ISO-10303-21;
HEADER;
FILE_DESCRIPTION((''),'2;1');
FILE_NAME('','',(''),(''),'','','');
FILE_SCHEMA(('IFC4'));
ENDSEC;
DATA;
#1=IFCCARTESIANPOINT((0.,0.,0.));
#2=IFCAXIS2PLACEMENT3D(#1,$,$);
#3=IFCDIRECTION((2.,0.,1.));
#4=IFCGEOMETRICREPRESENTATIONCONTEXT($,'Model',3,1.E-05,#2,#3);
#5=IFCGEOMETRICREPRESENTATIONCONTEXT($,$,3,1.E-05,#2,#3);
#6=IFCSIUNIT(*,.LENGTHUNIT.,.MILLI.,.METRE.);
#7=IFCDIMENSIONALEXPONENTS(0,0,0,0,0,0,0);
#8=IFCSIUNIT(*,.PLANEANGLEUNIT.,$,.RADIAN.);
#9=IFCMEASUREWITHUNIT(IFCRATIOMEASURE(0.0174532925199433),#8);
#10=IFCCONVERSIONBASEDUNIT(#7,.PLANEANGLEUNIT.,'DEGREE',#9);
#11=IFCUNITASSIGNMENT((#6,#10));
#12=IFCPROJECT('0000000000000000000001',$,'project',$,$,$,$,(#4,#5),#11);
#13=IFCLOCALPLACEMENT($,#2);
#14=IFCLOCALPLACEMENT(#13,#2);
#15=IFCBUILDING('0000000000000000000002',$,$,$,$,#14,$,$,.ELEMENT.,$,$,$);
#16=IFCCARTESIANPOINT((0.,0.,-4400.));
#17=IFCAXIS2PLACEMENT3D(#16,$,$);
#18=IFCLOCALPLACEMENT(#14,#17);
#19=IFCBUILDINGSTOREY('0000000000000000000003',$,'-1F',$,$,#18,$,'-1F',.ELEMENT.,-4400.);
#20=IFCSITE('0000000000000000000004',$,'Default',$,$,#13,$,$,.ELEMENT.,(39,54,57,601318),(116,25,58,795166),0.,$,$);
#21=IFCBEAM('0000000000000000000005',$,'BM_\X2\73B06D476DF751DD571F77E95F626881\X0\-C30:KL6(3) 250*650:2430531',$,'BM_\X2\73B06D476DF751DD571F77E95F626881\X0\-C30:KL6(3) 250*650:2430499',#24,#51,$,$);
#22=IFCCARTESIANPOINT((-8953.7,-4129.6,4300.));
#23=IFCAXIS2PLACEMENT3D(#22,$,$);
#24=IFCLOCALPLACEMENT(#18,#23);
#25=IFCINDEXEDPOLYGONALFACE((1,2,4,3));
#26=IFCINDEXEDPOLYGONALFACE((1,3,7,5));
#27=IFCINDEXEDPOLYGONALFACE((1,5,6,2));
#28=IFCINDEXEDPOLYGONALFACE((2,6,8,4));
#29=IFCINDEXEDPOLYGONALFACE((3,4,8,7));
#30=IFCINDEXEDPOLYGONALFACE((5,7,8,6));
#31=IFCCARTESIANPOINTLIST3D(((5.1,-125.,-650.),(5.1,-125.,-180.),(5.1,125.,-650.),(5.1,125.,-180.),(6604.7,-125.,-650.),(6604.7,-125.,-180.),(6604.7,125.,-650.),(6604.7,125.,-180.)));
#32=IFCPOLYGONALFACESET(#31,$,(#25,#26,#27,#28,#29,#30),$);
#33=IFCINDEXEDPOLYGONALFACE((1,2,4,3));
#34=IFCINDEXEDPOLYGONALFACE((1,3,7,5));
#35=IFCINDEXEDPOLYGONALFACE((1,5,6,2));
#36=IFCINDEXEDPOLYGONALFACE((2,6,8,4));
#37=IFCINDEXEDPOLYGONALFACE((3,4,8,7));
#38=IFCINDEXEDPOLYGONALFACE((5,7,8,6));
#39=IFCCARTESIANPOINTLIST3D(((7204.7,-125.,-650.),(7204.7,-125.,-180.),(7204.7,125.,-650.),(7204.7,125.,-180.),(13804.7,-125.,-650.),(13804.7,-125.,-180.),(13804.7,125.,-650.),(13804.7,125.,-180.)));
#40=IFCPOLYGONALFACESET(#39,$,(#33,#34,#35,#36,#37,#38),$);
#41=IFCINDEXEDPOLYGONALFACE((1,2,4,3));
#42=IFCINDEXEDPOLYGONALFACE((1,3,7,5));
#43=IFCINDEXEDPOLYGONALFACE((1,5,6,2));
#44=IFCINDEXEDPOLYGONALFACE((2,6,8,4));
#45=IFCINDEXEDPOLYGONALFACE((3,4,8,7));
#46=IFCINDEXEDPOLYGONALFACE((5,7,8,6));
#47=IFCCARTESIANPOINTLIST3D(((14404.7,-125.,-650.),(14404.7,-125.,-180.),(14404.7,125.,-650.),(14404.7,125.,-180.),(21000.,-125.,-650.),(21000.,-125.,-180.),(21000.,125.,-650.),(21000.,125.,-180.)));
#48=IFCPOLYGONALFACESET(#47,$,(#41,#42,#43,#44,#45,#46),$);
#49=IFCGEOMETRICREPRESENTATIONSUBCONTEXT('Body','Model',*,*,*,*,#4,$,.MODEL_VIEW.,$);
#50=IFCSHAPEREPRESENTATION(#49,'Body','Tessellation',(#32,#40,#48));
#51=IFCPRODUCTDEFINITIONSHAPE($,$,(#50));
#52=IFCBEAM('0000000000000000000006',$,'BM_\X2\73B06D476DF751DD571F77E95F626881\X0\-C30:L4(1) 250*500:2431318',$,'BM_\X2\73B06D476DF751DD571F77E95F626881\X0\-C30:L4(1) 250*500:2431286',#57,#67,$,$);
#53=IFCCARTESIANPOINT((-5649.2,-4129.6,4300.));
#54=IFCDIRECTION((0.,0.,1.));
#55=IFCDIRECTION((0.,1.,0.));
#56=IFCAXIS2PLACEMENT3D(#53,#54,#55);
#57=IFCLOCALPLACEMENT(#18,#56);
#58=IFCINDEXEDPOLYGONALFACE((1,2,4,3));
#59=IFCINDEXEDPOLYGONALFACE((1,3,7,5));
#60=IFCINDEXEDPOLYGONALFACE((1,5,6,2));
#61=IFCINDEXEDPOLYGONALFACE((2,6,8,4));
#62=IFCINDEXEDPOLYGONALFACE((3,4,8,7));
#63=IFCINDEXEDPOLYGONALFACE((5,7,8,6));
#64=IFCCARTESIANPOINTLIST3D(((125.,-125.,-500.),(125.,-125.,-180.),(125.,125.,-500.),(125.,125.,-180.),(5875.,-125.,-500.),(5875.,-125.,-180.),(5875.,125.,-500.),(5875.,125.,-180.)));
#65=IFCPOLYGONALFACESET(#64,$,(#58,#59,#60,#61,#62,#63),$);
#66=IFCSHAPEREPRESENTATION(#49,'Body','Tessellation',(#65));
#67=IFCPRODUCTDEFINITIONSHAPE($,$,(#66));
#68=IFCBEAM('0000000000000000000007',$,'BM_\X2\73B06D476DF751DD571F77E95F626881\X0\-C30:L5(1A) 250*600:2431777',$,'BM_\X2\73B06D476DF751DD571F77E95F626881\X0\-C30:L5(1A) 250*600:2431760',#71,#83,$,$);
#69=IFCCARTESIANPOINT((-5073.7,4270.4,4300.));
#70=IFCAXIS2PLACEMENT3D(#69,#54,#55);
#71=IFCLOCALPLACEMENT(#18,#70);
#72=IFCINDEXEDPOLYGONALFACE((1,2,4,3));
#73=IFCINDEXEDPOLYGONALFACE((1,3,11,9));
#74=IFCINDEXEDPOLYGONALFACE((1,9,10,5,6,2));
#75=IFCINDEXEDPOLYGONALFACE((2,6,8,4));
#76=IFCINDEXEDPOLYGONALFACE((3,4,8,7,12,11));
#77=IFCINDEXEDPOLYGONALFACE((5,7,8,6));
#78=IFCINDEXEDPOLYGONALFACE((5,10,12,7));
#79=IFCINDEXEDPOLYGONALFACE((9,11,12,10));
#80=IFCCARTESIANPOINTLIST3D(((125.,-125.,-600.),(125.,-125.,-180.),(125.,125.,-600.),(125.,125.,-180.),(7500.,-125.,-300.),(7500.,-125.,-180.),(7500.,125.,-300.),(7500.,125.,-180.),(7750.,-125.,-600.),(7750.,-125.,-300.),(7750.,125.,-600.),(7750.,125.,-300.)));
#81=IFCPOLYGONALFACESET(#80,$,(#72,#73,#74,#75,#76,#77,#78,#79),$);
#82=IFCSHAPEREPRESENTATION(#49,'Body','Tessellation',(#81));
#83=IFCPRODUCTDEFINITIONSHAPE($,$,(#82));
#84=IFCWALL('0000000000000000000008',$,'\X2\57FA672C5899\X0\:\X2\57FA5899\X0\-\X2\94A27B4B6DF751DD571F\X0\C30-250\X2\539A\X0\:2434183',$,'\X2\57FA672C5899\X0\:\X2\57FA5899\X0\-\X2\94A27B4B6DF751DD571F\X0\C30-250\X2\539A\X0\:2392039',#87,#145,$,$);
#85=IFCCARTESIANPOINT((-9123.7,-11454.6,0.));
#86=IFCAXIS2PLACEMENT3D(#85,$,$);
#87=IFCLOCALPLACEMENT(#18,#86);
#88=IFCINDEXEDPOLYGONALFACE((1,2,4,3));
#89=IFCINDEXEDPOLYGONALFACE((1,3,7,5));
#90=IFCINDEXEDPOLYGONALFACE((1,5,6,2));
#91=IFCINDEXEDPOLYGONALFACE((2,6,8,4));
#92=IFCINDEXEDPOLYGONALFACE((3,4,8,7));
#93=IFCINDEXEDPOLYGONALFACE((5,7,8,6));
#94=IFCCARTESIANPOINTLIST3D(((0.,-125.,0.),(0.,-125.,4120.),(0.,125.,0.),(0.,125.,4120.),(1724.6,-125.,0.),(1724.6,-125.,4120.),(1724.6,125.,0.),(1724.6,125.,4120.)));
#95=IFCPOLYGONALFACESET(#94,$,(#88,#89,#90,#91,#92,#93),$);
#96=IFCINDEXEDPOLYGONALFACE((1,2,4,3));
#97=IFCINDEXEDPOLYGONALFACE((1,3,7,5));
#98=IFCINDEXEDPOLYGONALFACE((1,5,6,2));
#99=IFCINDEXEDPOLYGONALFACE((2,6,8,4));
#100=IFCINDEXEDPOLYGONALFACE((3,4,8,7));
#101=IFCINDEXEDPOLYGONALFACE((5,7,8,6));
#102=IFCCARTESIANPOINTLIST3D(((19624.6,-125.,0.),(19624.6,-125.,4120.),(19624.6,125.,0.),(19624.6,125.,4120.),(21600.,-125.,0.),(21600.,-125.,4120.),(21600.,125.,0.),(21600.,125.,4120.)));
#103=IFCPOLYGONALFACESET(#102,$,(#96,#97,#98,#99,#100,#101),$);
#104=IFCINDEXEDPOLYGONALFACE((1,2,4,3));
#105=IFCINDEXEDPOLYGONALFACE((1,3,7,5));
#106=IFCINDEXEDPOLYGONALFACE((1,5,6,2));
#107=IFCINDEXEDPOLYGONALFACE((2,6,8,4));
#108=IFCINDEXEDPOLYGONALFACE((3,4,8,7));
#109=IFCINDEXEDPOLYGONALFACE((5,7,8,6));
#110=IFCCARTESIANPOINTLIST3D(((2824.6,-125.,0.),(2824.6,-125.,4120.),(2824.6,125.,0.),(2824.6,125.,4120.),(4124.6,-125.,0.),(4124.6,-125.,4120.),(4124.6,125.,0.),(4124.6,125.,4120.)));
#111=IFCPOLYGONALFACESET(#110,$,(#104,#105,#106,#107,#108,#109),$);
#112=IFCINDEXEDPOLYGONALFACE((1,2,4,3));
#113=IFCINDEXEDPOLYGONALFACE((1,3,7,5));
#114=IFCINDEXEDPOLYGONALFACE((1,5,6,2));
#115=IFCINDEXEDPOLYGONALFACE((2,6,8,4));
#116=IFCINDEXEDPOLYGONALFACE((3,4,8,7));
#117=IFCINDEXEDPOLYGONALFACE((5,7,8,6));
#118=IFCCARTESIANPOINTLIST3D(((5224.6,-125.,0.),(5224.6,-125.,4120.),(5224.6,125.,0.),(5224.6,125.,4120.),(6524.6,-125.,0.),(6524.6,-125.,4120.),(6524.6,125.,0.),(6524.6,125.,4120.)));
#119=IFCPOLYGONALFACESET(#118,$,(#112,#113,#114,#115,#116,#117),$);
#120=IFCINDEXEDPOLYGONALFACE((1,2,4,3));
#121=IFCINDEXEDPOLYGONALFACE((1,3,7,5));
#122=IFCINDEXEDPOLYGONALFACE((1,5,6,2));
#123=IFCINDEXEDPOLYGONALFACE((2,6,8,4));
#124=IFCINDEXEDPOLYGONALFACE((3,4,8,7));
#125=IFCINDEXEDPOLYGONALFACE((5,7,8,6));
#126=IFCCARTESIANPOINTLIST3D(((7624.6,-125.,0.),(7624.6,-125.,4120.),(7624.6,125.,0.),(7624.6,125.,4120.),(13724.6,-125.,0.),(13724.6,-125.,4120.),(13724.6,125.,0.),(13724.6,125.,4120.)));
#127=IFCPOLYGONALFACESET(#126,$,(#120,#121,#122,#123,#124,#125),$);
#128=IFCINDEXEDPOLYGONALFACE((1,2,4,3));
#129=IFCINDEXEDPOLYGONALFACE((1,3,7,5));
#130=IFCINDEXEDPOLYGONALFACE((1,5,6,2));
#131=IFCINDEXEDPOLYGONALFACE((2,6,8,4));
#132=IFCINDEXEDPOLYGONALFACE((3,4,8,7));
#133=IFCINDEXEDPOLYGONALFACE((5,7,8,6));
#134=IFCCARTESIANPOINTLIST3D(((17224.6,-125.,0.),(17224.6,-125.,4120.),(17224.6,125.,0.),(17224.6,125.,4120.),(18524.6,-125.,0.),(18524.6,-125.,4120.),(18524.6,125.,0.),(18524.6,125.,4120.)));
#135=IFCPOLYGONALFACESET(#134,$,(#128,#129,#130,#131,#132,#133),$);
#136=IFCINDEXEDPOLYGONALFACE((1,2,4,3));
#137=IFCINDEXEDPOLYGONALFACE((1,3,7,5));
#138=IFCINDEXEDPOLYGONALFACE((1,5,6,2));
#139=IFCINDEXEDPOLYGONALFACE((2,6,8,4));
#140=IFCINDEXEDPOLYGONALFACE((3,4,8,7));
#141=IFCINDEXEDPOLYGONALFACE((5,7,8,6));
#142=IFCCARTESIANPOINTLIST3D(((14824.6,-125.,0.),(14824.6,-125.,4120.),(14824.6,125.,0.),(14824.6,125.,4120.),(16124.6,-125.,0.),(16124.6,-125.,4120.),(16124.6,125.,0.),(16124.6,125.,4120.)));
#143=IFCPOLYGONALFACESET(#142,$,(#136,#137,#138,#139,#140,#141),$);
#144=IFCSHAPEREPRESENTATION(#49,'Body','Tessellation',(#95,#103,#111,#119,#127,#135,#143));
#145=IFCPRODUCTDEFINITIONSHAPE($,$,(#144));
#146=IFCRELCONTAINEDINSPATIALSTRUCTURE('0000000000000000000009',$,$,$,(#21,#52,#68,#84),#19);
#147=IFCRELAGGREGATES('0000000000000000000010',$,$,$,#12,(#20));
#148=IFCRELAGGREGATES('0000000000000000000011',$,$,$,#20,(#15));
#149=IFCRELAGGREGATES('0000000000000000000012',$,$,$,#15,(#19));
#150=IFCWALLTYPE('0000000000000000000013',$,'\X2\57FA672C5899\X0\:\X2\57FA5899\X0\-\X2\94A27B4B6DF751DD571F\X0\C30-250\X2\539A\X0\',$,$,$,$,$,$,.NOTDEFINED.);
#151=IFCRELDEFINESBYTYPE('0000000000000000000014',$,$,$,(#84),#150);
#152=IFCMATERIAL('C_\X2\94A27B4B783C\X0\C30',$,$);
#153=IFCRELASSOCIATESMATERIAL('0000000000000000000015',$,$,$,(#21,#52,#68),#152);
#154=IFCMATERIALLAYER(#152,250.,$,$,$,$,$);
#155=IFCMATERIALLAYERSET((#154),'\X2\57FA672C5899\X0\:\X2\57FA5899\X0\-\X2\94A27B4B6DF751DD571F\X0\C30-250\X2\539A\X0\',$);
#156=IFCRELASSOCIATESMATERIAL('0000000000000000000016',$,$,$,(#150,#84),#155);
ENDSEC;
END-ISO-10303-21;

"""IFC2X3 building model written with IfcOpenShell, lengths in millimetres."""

from ifc_helpers import new_model, entity, si_unit, converted_unit, direction, frame, frame_2d, origin, origin_2d_with_axis, place, context, subcontext, project, spatial, polyline, rectangle, extrude, clip, bounded_halfspace, material, layer, layer_set, type_object, element, save


model = new_model("IFC2X3")

# Units and contexts
model_context = context("Model", 3, precision=1e-05, world=origin(), true_north=direction((2.0, 0.0, 1.0)))
context_of_model = context(None, 3, precision=1e-05, world=origin(), true_north=direction((2.0, 0.0, 1.0)))
body_context = subcontext(model_context, "Body", "Model", "MODEL_VIEW")
ifc_project = project(units=[si_unit("LENGTHUNIT", "METRE", prefix="MILLI"), converted_unit("PLANEANGLEUNIT", "DEGREE", entity("IfcRatioMeasure", 0.0174532925199433), si_unit("PLANEANGLEUNIT", "RADIAN"), dimensions=[0, 0, 0, 0, 0, 0, 0])], contexts=[model_context, context_of_model])

# Site, building, storey
site_placement = place(None, origin())
site = spatial("IfcSite", under=ifc_project, at=site_placement, Name="Default", CompositionType="ELEMENT", RefLatitude=(39, 54, 57, 601318), RefLongitude=(116, 25, 58, 795166), RefElevation=0.0)
building_placement = place(site_placement, origin())
building = spatial("IfcBuilding", under=site, at=building_placement, CompositionType="ELEMENT")
storey_placement = place(building_placement, frame((0.0, 0.0, -4400.0)))
storey = spatial("IfcBuildingStorey", under=building, at=storey_placement, Name="-1F", LongName="-1F", CompositionType="ELEMENT", Elevation=-4400.0)

# Shared definitions
ifc_material_1 = material(Name="C_钢筋砼C30")

# Beams
beam_1_placement = place(storey_placement, frame((-8953.7, -4129.6, 4300.0)))
element("IfcBeam", 1, at=beam_1_placement, inside=storey, material=ifc_material_1, Name="BM_现浇混凝土矩形梁-C30:KL6(3) 250*650:2430531", ObjectType="BM_现浇混凝土矩形梁-C30:KL6(3) 250*650:2430499", context=body_context, shape_type="SweptSolid", body=[
    extrude(rectangle(XDim=470.0, YDim=250.0, at=origin_2d_with_axis()), frame((5.1, 0.0, -415.0), z_axis=(1.0, 0.0, 0.0), x_axis=(0.0, 0.0, 1.0)), (0.0, 0.0, 1.0), 6599.6),
    extrude(rectangle(XDim=470.0, YDim=250.0, at=origin_2d_with_axis()), frame((7204.7, 0.0, -415.0), z_axis=(1.0, 0.0, 0.0), x_axis=(0.0, 0.0, 1.0)), (0.0, 0.0, 1.0), 6600.0),
    extrude(rectangle(XDim=470.0, YDim=250.0, at=frame_2d((0.0, 0.0), x_axis=(1.0, 0.0))), frame((14404.7, 0.0, -415.0), z_axis=(1.0, 0.0, 0.0), x_axis=(0.0, 0.0, 1.0)), (0.0, 0.0, 1.0), 6595.3),
])
beam_2_placement = place(storey_placement, frame((-5649.2, -4129.6, 4300.0), z_axis=(0.0, 0.0, 1.0), x_axis=(0.0, 1.0, 0.0)))
element("IfcBeam", 2, at=beam_2_placement, inside=storey, material=ifc_material_1, Name="BM_现浇混凝土矩形梁-C30:L4(1) 250*500:2431318", ObjectType="BM_现浇混凝土矩形梁-C30:L4(1) 250*500:2431286", context=body_context, shape_type="SweptSolid", body=[
    extrude(rectangle(XDim=320.0, YDim=250.0, at=frame_2d((0.0, 0.0), x_axis=(1.0, 0.0))), frame((125.0, 0.0, -340.0), z_axis=(1.0, 0.0, 0.0), x_axis=(0.0, 0.0, -1.0)), (0.0, 0.0, 1.0), 5750.0),
])
beam_3_placement = place(storey_placement, frame((-5073.7, 4270.4, 4300.0), z_axis=(0.0, 0.0, 1.0), x_axis=(0.0, 1.0, 0.0)))
element("IfcBeam", 3, at=beam_3_placement, inside=storey, material=ifc_material_1, Name="BM_现浇混凝土矩形梁-C30:L5(1A) 250*600:2431777", ObjectType="BM_现浇混凝土矩形梁-C30:L5(1A) 250*600:2431760", context=body_context, shape_type="Clipping", body=[
    clip(extrude(rectangle(XDim=420.0, YDim=250.0, at=frame_2d((0.0, 0.0), x_axis=(0.0, 1.0))), frame((125.0, 0.0, -390.0), z_axis=(1.0, 0.0, 0.0), x_axis=(0.0, 1.0, 0.0)), (0.0, 0.0, 1.0), 7625.0), bounded_halfspace(frame((7500.0, 13637.7, -300.0), z_axis=(1.0, 0.0, 0.0), x_axis=(0.0, 0.0, 1.0)), False, frame((125.0, 0.0, -390.0), z_axis=(1.0, 0.0, 0.0), x_axis=(0.0, 1.0, 0.0)), polyline([(-125.0, 90.0), (125.0, 90.0), (125.0, 210.0), (-125.0, 210.0), (-125.0, 90.0)]))),
])

# Wall
ifc_layer_1 = layer(ifc_material_1, 250.0)
ifc_layer_set_1 = layer_set([ifc_layer_1], Name="基本墙:基墙-钢筋混凝土C30-250厚")
wall_type_1 = type_object("IfcWallType", Name="基本墙:基墙-钢筋混凝土C30-250厚", PredefinedType="NOTDEFINED", material=ifc_layer_set_1)
wall_1_placement = place(storey_placement, frame((-9123.7, -11454.6, 0.0)))
element("IfcWall", 4, at=wall_1_placement, inside=storey, type_object=wall_type_1, material=ifc_layer_set_1, Name="基本墙:基墙-钢筋混凝土C30-250厚:2434183", ObjectType="基本墙:基墙-钢筋混凝土C30-250厚:2392039", context=body_context, shape_type="SweptSolid", body=[
    extrude(rectangle(XDim=1724.6, YDim=250.0, at=frame_2d((0.0, 0.0), x_axis=(1.0, 0.0))), frame((862.3, 0.0, 0.0)), (0.0, 0.0, 1.0), 4120.0),
    extrude(rectangle(XDim=1975.4, YDim=250.0, at=frame_2d((147.5, 25.0), x_axis=(1.0, 0.0))), frame((20759.9, 25.0, 0.0), z_axis=(0.0, 0.0, 1.0), x_axis=(-1.0, 0.0, 0.0)), (0.0, 0.0, 1.0), 4120.0),
    extrude(rectangle(XDim=1300.0, YDim=250.0, at=frame_2d((0.0, 0.0), x_axis=(1.0, 0.0))), frame((3474.6, 0.0, 0.0)), (0.0, 0.0, 1.0), 4120.0),
    extrude(rectangle(XDim=1300.0, YDim=250.0, at=origin_2d_with_axis()), frame((5874.6, 0.0, 0.0), z_axis=(0.0, 0.0, 1.0), x_axis=(-1.0, 0.0, 0.0)), (0.0, 0.0, 1.0), 4120.0),
    extrude(rectangle(XDim=6100.0, YDim=250.0, at=frame_2d((0.0, 0.0), x_axis=(1.0, 0.0))), frame((10674.6, 0.0, 0.0)), (0.0, 0.0, 1.0), 4120.0),
    extrude(rectangle(XDim=1300.0, YDim=250.0, at=frame_2d((0.0, 0.0), x_axis=(1.0, 0.0))), frame((17874.6, 0.0, 0.0), z_axis=(0.0, 0.0, 1.0), x_axis=(-1.0, 0.0, 0.0)), (0.0, 0.0, 1.0), 4120.0),
    extrude(rectangle(XDim=1300.0, YDim=250.0, at=origin_2d_with_axis()), frame((15474.6, 0.0, 0.0)), (0.0, 0.0, 1.0), 4120.0),
])

save(model, "model.ifc")
